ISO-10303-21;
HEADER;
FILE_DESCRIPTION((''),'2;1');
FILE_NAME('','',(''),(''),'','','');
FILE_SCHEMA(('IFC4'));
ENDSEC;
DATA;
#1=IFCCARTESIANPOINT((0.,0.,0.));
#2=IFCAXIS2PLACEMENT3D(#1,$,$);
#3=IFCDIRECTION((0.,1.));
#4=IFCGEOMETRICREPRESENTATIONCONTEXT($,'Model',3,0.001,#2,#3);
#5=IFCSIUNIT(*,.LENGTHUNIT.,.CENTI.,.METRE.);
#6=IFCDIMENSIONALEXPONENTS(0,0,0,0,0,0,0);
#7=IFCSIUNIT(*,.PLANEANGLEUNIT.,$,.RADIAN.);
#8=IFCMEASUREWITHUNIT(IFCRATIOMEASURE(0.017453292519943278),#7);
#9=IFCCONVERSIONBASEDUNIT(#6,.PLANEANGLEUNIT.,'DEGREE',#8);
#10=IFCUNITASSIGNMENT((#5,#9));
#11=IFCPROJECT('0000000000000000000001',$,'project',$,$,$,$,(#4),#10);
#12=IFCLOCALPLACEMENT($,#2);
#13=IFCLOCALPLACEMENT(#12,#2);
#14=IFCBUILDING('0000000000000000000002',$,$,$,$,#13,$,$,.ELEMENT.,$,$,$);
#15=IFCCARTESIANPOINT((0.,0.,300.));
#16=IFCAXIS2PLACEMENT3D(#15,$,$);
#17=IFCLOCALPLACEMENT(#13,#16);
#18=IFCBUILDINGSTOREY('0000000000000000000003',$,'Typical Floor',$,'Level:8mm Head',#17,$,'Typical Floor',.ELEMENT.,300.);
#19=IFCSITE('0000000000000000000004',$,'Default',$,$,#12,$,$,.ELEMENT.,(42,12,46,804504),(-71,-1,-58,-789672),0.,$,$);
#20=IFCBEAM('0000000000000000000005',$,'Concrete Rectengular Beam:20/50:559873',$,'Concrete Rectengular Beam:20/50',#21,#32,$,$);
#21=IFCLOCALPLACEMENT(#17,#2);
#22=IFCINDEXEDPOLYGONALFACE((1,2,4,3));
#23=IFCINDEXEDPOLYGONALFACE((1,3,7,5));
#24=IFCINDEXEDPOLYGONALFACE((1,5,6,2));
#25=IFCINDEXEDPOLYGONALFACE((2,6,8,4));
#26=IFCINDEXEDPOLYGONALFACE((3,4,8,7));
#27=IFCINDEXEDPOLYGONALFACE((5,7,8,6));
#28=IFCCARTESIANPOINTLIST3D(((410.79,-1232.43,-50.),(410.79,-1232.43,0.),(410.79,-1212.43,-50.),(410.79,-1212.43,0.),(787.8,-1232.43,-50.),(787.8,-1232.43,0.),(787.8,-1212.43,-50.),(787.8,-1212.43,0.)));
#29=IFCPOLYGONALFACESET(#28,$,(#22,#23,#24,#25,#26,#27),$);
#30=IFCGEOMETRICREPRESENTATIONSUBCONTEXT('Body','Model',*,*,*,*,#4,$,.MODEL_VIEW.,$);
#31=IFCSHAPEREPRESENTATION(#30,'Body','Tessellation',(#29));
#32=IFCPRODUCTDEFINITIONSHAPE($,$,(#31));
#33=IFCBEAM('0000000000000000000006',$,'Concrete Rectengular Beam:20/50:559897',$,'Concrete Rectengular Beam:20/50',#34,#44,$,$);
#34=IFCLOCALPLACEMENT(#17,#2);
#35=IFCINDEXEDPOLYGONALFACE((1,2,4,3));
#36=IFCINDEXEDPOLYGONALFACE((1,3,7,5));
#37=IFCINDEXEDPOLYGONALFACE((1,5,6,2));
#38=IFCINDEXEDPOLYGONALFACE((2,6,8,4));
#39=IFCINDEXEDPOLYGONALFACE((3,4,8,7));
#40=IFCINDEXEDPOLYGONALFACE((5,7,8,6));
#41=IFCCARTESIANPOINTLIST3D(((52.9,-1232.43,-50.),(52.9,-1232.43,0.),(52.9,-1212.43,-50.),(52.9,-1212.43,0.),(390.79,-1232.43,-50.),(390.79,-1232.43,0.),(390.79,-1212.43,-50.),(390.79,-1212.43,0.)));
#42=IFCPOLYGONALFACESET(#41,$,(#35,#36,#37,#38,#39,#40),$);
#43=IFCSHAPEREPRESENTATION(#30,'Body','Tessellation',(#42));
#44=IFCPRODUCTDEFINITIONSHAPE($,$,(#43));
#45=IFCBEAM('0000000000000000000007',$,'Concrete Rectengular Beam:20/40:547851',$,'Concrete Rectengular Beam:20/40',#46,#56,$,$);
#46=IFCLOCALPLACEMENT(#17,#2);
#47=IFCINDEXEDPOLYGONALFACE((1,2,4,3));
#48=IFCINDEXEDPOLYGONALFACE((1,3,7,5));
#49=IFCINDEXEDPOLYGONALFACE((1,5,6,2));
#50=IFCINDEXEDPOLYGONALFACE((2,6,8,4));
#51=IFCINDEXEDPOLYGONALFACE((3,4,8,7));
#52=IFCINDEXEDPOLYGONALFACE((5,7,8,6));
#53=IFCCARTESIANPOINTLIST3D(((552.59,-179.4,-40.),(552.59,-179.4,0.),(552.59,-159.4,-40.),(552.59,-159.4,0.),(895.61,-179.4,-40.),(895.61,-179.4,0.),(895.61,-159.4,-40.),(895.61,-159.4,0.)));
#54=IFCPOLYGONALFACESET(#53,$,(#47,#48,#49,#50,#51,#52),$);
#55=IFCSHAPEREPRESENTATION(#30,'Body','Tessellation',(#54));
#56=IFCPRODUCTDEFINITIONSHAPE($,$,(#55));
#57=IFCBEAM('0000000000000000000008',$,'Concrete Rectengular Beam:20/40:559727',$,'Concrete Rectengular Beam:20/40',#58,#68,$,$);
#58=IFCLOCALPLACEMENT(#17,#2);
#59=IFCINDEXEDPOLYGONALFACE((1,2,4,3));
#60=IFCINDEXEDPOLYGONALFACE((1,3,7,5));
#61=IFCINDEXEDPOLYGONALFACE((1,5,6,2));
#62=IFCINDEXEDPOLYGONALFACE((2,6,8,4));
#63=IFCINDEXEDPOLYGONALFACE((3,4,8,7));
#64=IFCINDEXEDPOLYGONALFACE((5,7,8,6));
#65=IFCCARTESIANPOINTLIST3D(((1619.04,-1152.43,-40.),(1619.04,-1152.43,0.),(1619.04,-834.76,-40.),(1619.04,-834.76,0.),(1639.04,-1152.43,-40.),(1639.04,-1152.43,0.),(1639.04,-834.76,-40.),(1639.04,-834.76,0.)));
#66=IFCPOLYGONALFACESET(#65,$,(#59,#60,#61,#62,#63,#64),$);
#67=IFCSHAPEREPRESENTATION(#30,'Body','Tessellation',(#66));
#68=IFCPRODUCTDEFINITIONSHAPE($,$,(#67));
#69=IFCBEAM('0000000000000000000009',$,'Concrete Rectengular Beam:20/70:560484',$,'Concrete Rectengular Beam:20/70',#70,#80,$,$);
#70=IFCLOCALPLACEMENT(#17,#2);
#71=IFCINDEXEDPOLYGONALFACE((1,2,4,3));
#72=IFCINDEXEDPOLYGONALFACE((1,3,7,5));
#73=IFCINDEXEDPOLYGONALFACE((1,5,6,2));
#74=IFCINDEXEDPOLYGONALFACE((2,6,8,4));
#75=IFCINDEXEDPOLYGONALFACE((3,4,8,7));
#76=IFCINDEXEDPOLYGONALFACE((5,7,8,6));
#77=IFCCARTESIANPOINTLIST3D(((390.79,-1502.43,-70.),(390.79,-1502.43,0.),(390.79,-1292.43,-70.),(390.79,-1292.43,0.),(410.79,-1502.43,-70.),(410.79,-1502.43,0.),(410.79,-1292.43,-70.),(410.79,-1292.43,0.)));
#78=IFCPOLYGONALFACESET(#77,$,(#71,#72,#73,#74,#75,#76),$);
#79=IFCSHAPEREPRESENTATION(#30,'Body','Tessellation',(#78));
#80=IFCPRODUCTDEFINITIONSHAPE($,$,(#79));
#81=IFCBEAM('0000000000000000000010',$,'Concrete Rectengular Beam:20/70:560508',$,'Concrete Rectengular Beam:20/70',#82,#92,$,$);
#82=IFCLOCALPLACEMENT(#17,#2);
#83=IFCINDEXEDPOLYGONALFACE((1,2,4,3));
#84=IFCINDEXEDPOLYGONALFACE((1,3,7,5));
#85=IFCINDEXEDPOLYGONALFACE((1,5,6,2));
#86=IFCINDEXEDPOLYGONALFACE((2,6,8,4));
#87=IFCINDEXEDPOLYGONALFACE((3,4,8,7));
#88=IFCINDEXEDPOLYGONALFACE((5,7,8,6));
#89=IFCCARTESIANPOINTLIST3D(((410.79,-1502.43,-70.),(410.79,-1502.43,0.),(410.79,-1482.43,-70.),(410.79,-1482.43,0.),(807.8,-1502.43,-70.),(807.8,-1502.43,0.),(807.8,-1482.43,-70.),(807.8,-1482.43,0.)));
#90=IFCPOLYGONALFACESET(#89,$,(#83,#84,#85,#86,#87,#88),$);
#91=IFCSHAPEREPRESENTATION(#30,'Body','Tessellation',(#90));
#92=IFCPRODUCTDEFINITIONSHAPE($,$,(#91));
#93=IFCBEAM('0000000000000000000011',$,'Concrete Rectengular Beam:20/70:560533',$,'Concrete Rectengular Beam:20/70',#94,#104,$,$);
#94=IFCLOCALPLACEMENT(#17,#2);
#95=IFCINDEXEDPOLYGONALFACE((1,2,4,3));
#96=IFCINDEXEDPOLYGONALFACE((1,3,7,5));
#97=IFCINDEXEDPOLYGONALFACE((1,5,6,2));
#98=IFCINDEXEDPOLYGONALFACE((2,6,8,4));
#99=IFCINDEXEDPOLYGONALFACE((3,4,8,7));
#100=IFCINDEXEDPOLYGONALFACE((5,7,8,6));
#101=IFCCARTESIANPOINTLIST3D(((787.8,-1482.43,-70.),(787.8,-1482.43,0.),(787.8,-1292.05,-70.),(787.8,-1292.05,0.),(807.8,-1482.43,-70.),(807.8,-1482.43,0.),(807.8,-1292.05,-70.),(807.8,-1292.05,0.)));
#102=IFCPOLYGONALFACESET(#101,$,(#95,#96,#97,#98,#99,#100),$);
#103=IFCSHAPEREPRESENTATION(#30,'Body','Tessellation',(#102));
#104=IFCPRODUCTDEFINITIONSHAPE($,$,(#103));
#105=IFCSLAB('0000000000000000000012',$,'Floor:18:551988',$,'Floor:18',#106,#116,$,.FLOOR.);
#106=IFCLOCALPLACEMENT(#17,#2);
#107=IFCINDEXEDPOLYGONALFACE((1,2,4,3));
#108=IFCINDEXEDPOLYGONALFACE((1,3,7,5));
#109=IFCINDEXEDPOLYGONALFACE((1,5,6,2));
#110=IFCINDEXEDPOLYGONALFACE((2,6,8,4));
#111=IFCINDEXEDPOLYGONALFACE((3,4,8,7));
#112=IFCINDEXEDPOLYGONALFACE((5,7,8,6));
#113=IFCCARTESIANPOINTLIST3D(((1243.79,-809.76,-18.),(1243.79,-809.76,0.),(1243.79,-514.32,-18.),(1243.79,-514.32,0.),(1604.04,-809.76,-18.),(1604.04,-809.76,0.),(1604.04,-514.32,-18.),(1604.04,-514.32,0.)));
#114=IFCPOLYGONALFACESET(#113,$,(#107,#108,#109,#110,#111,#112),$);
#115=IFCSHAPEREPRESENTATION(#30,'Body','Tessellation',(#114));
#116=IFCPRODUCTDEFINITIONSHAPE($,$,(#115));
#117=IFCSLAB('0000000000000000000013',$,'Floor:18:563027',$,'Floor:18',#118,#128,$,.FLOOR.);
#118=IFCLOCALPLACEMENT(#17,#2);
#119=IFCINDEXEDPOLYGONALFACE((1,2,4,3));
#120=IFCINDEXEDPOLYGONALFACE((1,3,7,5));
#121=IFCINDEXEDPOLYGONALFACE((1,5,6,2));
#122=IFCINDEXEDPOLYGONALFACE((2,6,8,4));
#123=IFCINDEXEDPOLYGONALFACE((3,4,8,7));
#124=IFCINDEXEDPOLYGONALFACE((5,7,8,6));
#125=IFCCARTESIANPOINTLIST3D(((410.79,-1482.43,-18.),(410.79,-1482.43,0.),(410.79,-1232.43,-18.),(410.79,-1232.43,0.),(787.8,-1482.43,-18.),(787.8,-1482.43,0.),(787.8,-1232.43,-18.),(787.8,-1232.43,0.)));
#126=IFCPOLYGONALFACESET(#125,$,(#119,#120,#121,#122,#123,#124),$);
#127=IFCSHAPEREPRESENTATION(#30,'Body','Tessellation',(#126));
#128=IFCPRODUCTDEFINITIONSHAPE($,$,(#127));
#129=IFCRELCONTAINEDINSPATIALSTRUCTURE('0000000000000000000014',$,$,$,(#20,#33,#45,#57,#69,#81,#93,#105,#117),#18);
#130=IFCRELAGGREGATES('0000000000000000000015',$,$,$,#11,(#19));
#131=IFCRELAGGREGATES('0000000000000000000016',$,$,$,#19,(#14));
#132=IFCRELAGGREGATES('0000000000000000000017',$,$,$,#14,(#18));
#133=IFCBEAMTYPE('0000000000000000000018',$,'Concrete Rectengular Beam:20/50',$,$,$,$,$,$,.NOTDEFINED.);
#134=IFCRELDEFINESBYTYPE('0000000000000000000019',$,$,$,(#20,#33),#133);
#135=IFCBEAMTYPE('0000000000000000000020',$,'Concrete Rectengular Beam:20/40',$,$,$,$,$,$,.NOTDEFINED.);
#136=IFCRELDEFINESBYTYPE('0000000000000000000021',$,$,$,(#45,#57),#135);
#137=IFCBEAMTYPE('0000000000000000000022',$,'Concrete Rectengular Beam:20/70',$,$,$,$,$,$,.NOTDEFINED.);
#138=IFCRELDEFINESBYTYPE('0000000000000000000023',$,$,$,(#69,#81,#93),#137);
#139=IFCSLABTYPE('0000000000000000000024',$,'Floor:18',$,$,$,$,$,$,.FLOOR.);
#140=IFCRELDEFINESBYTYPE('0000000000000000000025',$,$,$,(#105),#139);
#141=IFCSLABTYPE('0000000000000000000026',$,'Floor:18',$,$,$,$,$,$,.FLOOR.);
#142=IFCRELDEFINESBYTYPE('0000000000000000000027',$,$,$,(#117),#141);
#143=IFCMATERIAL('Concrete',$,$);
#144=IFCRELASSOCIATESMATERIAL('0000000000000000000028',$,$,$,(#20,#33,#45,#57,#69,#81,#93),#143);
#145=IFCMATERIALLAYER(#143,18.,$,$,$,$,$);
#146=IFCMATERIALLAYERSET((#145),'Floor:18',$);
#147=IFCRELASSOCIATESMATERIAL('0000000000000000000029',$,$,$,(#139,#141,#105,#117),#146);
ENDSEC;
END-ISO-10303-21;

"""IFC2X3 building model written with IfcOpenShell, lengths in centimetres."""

from ifc_helpers import new_model, entity, si_unit, converted_unit, direction, frame, frame_2d, origin, origin_2d_with_axis, place, context, subcontext, project, spatial, rectangle, extrude, material, layer, layer_set, layer_usage, type_object, element, save


model = new_model("IFC2X3")

# Units and contexts
model_context = context("Model", 3, precision=0.001, world=origin(), true_north=direction((0.0, 1.0)))
body_context = subcontext(model_context, "Body", "Model", "MODEL_VIEW")
ifc_project = project(units=[si_unit("LENGTHUNIT", "METRE", prefix="CENTI"), converted_unit("PLANEANGLEUNIT", "DEGREE", entity("IfcRatioMeasure", 0.017453292519943278), si_unit("PLANEANGLEUNIT", "RADIAN"), dimensions=[0, 0, 0, 0, 0, 0, 0])], contexts=[model_context])

# Site, building, storey
site_placement = place(None, origin())
site = spatial("IfcSite", under=ifc_project, at=site_placement, Name="Default", CompositionType="ELEMENT", RefLatitude=(42, 12, 46, 804504), RefLongitude=(-71, -1, -58, -789672), RefElevation=0.0)
building_placement = place(site_placement, origin())
building = spatial("IfcBuilding", under=site, at=building_placement, CompositionType="ELEMENT")
storey_placement = place(building_placement, frame((0.0, 0.0, 300.0)))
storey = spatial("IfcBuildingStorey", under=building, at=storey_placement, Name="Typical Floor", ObjectType="Level:8mm Head", LongName="Typical Floor", CompositionType="ELEMENT", Elevation=300.0)

# Beams
ifc_material = material(Name="Concrete")
beam_type_1 = type_object("IfcBeamType", Name="Concrete Rectengular Beam:20/50", PredefinedType="NOTDEFINED")
beam_1_placement = place(storey_placement, frame((797.8, -1222.43, 0.0), z_axis=(0.0, 0.0, 1.0), x_axis=(-1.0, 0.0, 0.0)))
element("IfcBeam", 1, at=beam_1_placement, inside=storey, type_object=beam_type_1, material=ifc_material, Name="Concrete Rectengular Beam:20/50:559873", ObjectType="Concrete Rectengular Beam:20/50", context=body_context, shape_type="SweptSolid", body=[
    extrude(rectangle(XDim=50.0, YDim=20.0, at=frame_2d((0.0, 0.0), x_axis=(1.0, 0.0))), frame((10.0, 0.0, -25.0), z_axis=(1.0, 0.0, 0.0), x_axis=(0.0, 0.0, -1.0)), (0.0, 0.0, 1.0), 377.01),
])
beam_2_placement = place(storey_placement, frame((400.79, -1222.43, 0.0), z_axis=(0.0, 0.0, 1.0), x_axis=(-1.0, 0.0, 0.0)))
element("IfcBeam", 2, at=beam_2_placement, inside=storey, type_object=beam_type_1, material=ifc_material, Name="Concrete Rectengular Beam:20/50:559897", ObjectType="Concrete Rectengular Beam:20/50", context=body_context, shape_type="SweptSolid", body=[
    extrude(rectangle(XDim=50.0, YDim=20.0, at=frame_2d((0.0, 0.0), x_axis=(1.0, 0.0))), frame((10.0, 0.0, -25.0), z_axis=(1.0, 0.0, 0.0), x_axis=(0.0, 0.0, -1.0)), (0.0, 0.0, 1.0), 337.88),
])
beam_type_2 = type_object("IfcBeamType", Name="Concrete Rectengular Beam:20/40", PredefinedType="NOTDEFINED")
beam_3_placement = place(storey_placement, frame((905.61, -169.4, 0.0), z_axis=(0.0, 0.0, 1.0), x_axis=(-1.0, 0.0, 0.0)))
element("IfcBeam", 3, at=beam_3_placement, inside=storey, type_object=beam_type_2, material=ifc_material, Name="Concrete Rectengular Beam:20/40:547851", ObjectType="Concrete Rectengular Beam:20/40", context=body_context, shape_type="SweptSolid", body=[
    extrude(rectangle(XDim=40.0, YDim=20.0, at=origin_2d_with_axis()), frame((10.0, 0.0, -20.0), z_axis=(1.0, 0.0, 0.0), x_axis=(0.0, 0.0, -1.0)), (0.0, 0.0, 1.0), 343.02),
])
beam_4_placement = place(storey_placement, frame((1629.04, -1162.43, 0.0), z_axis=(0.0, 0.0, 1.0), x_axis=(0.0, 1.0, 0.0)))
element("IfcBeam", 4, at=beam_4_placement, inside=storey, type_object=beam_type_2, material=ifc_material, Name="Concrete Rectengular Beam:20/40:559727", ObjectType="Concrete Rectengular Beam:20/40", context=body_context, shape_type="SweptSolid", body=[
    extrude(rectangle(XDim=40.0, YDim=20.0, at=origin_2d_with_axis()), frame((10.0, 0.0, -20.0), z_axis=(1.0, 0.0, 0.0), x_axis=(0.0, 0.0, -1.0)), (0.0, 0.0, 1.0), 317.67),
])
beam_type_3 = type_object("IfcBeamType", Name="Concrete Rectengular Beam:20/70", PredefinedType="NOTDEFINED")
beam_5_placement = place(storey_placement, frame((400.79, -1282.43, 0.0), z_axis=(0.0, 0.0, 1.0), x_axis=(0.0, -1.0, 0.0)))
element("IfcBeam", 5, at=beam_5_placement, inside=storey, type_object=beam_type_3, material=ifc_material, Name="Concrete Rectengular Beam:20/70:560484", ObjectType="Concrete Rectengular Beam:20/70", context=body_context, shape_type="SweptSolid", body=[
    extrude(rectangle(XDim=70.0, YDim=20.0, at=origin_2d_with_axis()), frame((10.0, 0.0, -35.0), z_axis=(1.0, 0.0, 0.0), x_axis=(0.0, 0.0, -1.0)), (0.0, 0.0, 1.0), 210.0),
])
beam_6_placement = place(storey_placement, frame((400.79, -1492.43, 0.0)))
element("IfcBeam", 6, at=beam_6_placement, inside=storey, type_object=beam_type_3, material=ifc_material, Name="Concrete Rectengular Beam:20/70:560508", ObjectType="Concrete Rectengular Beam:20/70", context=body_context, shape_type="SweptSolid", body=[
    extrude(rectangle(XDim=70.0, YDim=20.0, at=frame_2d((0.0, 0.0), x_axis=(1.0, 0.0))), frame((10.0, 0.0, -35.0), z_axis=(1.0, 0.0, 0.0), x_axis=(0.0, 0.0, -1.0)), (0.0, 0.0, 1.0), 397.01),
])
beam_7_placement = place(storey_placement, frame((797.8, -1492.43, 0.0), z_axis=(0.0, 0.0, 1.0), x_axis=(0.0, 1.0, 0.0)))
element("IfcBeam", 7, at=beam_7_placement, inside=storey, type_object=beam_type_3, material=ifc_material, Name="Concrete Rectengular Beam:20/70:560533", ObjectType="Concrete Rectengular Beam:20/70", context=body_context, shape_type="SweptSolid", body=[
    extrude(rectangle(XDim=70.0, YDim=20.0, at=frame_2d((0.0, 0.0), x_axis=(1.0, 0.0))), frame((10.0, 0.0, -35.0), z_axis=(1.0, 0.0, 0.0), x_axis=(0.0, 0.0, -1.0)), (0.0, 0.0, 1.0), 190.38),
])

# Slabs
ifc_layer = layer(ifc_material, 18.0)
ifc_layer_set = layer_set([ifc_layer], Name="Floor:18")
ifc_layer_usage_1 = layer_usage(ifc_layer_set, "AXIS3", "POSITIVE", 0.0)
slab_type_1 = type_object("IfcSlabType", Name="Floor:18", PredefinedType="FLOOR", material=ifc_layer_set)
slab_1_placement = place(storey_placement, origin())
element("IfcSlab", 8, at=slab_1_placement, inside=storey, type_object=slab_type_1, material=ifc_layer_usage_1, Name="Floor:18:551988", ObjectType="Floor:18", PredefinedType="FLOOR", context=body_context, shape_type="SweptSolid", body=[
    extrude(rectangle(XDim=295.44, YDim=360.26, at=frame_2d((0.0, 0.0), x_axis=(1.0, 0.0))), frame((1423.92, -662.04, 0.0), z_axis=(0.0, 0.0, -1.0), x_axis=(0.0, 1.0, 0.0)), (0.0, 0.0, 1.0), 18.0),
])
ifc_layer_usage_2 = layer_usage(ifc_layer_set, "AXIS3", "POSITIVE", 0.0)
slab_type_2 = type_object("IfcSlabType", Name="Floor:18", PredefinedType="FLOOR", material=ifc_layer_set)
slab_2_placement = place(storey_placement, origin())
element("IfcSlab", 9, at=slab_2_placement, inside=storey, type_object=slab_type_2, material=ifc_layer_usage_2, Name="Floor:18:563027", ObjectType="Floor:18", PredefinedType="FLOOR", context=body_context, shape_type="SweptSolid", body=[
    extrude(rectangle(XDim=250.0, YDim=377.01, at=frame_2d((0.0, 0.0), x_axis=(1.0, 0.0))), frame((599.29, -1357.43, 0.0), z_axis=(0.0, 0.0, -1.0), x_axis=(0.0, 1.0, 0.0)), (0.0, 0.0, 1.0), 18.0),
])

save(model, "model.ifc")
